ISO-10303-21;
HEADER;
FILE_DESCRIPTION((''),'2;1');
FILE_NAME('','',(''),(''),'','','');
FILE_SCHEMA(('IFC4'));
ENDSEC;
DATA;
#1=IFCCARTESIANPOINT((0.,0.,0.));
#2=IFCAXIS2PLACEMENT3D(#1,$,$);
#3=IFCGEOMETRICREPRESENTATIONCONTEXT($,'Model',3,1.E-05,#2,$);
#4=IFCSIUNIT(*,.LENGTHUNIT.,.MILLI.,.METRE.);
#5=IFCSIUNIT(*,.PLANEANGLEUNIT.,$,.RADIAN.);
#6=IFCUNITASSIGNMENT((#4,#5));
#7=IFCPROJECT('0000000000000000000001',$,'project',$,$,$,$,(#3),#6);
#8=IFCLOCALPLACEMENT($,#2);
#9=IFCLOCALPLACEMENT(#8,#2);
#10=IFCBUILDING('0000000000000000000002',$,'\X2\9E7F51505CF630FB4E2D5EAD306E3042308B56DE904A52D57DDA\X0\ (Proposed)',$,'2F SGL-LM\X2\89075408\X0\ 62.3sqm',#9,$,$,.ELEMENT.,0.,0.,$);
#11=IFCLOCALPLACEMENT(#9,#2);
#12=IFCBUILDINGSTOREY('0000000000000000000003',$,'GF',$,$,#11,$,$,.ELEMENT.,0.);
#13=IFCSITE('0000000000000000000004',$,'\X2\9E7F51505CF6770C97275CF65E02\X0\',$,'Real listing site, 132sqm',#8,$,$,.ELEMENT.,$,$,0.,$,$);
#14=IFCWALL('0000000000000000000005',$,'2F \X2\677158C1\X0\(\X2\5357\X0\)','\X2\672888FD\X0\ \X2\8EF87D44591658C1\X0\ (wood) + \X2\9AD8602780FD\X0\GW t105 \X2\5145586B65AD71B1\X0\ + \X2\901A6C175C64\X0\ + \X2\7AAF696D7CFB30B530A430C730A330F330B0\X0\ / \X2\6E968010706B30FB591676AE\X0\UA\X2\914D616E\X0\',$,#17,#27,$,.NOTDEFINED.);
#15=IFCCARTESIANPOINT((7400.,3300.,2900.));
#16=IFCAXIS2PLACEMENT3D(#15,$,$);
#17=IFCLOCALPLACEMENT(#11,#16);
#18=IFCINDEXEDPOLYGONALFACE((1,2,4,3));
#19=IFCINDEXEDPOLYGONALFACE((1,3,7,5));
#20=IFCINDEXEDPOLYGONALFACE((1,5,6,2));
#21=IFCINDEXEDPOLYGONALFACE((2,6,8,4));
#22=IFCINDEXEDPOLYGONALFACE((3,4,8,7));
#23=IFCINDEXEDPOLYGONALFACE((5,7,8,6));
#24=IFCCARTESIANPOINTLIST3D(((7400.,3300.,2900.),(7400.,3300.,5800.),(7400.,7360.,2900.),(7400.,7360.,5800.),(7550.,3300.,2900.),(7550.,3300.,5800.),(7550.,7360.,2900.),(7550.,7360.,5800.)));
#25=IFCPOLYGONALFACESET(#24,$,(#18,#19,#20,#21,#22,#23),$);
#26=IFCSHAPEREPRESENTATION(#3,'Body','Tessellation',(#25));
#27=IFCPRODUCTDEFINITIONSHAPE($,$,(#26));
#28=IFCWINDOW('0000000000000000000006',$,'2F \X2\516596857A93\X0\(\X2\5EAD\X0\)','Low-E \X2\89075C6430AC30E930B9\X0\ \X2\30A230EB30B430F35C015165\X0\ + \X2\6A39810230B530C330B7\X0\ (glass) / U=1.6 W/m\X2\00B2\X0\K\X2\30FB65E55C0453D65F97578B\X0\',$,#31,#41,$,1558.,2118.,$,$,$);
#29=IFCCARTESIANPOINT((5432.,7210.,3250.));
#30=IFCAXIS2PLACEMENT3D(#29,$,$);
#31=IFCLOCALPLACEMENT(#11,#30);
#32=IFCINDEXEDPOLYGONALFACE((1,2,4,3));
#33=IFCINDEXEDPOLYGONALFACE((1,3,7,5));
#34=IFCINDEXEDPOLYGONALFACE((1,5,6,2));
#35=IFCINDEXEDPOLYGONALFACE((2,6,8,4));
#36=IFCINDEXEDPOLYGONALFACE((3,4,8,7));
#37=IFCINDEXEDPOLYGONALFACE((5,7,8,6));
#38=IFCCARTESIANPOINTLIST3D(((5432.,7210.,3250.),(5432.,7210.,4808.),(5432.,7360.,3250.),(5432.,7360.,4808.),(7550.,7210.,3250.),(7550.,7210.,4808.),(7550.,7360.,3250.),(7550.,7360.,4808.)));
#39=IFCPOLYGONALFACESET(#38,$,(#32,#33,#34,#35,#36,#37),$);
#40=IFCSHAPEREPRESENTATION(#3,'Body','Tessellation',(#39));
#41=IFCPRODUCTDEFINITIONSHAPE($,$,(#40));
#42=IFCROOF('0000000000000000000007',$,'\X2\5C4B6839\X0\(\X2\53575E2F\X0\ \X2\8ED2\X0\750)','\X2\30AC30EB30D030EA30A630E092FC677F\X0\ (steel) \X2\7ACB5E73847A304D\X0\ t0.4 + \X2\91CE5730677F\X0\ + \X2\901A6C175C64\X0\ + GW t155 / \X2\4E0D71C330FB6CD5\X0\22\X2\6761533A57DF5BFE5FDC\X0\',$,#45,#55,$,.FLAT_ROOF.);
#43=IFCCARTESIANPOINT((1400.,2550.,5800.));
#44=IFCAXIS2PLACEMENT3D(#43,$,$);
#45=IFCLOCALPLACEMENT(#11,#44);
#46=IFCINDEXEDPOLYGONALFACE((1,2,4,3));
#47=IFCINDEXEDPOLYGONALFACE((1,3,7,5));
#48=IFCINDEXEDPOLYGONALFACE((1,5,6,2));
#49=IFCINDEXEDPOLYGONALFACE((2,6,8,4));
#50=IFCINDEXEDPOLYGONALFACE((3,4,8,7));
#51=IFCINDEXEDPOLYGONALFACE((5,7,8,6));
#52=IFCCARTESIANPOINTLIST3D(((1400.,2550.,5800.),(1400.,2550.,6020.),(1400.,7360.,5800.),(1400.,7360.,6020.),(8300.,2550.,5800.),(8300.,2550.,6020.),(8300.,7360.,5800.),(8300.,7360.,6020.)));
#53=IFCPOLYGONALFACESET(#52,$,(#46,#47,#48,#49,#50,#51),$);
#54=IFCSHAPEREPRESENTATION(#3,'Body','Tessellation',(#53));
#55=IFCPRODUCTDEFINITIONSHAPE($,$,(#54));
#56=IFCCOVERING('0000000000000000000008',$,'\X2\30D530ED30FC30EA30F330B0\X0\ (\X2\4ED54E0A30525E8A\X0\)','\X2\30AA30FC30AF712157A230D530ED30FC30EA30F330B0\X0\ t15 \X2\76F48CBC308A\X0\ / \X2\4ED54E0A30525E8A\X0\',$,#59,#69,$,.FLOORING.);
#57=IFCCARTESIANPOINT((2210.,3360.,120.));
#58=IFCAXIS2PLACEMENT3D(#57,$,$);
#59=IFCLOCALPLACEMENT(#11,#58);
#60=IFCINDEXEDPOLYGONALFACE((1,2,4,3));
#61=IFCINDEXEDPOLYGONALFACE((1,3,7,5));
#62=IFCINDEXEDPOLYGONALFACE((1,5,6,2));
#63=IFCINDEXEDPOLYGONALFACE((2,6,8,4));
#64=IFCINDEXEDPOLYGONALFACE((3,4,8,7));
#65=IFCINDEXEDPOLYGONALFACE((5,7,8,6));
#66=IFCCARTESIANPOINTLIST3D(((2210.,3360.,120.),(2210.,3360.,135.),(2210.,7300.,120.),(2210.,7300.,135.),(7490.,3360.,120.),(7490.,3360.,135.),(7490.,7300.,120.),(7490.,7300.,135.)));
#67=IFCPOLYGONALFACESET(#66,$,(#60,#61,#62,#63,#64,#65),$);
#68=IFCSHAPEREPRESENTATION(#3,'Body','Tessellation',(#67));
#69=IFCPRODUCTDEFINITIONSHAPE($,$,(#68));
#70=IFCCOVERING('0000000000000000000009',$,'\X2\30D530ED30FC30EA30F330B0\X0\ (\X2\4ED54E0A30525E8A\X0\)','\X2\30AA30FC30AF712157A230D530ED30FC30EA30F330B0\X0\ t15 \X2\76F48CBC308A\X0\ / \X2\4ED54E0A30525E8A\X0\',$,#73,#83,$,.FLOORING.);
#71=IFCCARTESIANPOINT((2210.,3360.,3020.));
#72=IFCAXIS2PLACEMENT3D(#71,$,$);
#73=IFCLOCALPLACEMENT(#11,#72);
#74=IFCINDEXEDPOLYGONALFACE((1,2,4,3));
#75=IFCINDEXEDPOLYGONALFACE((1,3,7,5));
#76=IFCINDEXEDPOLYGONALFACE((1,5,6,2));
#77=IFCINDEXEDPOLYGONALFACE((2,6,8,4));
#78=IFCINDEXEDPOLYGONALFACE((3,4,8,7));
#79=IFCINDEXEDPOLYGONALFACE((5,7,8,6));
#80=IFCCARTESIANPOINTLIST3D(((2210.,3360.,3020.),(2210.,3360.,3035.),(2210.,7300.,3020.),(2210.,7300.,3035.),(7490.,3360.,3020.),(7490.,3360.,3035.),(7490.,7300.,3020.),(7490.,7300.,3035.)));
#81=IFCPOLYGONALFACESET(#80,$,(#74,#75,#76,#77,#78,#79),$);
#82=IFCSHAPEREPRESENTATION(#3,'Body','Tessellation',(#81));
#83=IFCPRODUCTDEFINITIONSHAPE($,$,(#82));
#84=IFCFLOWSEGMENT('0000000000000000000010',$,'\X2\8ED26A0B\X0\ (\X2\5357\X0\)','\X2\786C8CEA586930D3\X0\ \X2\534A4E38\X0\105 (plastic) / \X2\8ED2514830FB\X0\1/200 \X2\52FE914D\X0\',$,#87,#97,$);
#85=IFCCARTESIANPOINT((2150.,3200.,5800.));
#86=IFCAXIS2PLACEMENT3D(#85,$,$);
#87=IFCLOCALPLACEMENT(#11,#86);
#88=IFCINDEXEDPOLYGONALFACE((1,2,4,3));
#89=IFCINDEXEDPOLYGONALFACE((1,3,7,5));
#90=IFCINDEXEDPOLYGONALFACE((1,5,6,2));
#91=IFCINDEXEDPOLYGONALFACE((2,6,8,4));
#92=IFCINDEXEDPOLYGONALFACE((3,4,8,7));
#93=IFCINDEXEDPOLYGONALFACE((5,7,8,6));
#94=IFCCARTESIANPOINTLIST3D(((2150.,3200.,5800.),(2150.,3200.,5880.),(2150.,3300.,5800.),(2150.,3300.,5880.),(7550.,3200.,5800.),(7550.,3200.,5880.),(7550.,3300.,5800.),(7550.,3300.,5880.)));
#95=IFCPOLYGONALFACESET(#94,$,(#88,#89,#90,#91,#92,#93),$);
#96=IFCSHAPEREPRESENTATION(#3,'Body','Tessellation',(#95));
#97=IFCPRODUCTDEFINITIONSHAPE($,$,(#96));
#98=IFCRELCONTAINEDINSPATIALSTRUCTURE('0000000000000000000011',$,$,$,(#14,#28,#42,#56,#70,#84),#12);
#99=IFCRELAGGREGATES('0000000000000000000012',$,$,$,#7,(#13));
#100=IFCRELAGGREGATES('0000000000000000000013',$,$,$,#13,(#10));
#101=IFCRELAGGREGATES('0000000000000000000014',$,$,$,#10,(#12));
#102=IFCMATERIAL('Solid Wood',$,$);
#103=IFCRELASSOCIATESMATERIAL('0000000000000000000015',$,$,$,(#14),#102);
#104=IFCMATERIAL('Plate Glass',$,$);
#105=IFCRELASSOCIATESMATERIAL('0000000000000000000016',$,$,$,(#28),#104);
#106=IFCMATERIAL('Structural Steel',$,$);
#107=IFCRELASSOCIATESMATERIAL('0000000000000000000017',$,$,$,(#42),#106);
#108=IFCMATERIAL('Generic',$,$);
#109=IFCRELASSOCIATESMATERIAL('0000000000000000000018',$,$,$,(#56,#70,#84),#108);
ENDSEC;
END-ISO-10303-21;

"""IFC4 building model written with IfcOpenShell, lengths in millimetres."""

from ifc_helpers import new_model, si_unit, frame, frame_2d, origin, place, context, project, spatial, rectangle, extrude, material, element, fill, save


model = new_model("IFC4")

# Units and contexts
model_context = context("Model", 3, precision=1e-05, world=origin())
ifc_project = project(units=[si_unit("LENGTHUNIT", "METRE", prefix="MILLI"), si_unit("PLANEANGLEUNIT", "RADIAN")], contexts=[model_context])

# Site, building, storey
site_placement = place(None, origin())
site = spatial("IfcSite", under=ifc_project, at=site_placement, Name="鹿児島県霧島市", ObjectType="Real listing site, 132sqm", CompositionType="ELEMENT", RefElevation=0.0)
building_placement = place(site_placement, origin())
building = spatial("IfcBuilding", under=site, at=building_placement, Name="鹿児島・中庭のある回遊動線 (Proposed)", ObjectType="2F SGL-LM複合 62.3sqm", CompositionType="ELEMENT", ElevationOfRefHeight=0.0, ElevationOfTerrain=0.0)
storey_placement = place(building_placement, origin())
storey = spatial("IfcBuildingStorey", under=building, at=storey_placement, Name="GF", CompositionType="ELEMENT", Elevation=0.0)

# Shared definitions
ifc_material_1 = material(Name="Solid Wood")

# Wall, opening, window
ifc_material_2 = material(Name="Plate Glass")
wall_1_placement = place(storey_placement, frame((7400.0, 3300.0, 2900.0)))
wall_1 = element("IfcWall", 1, at=wall_1_placement, inside=storey, material=ifc_material_1, Name="2F 東壁(南)", Description="木製 軸組外壁 (wood) + 高性能GW t105 充填断熱 + 通気層 + 窯業系サイディング / 準耐火・外皮UA配慮", PredefinedType="NOTDEFINED", context=model_context, shape_type="SweptSolid", body=[
    extrude(rectangle(XDim=150.0, YDim=4060.0, at=frame_2d((75.0, 2030.0))), frame((7400.0, 3300.0, 2900.0)), (0.0, 0.0, 1.0), 2900.0),
])
opening_1_placement = place(storey_placement, frame((5432.0, 7210.0, 3250.0)))
opening_1 = element("IfcOpeningElement", 2, at=opening_1_placement, cuts=wall_1, PredefinedType="NOTDEFINED", context=model_context, shape_type="SweptSolid", body=[
    extrude(rectangle(XDim=2118.0, YDim=150.0, at=frame_2d((1059.0, 75.0))), frame((5432.0, 7210.0, 3250.0)), (0.0, 0.0, 1.0), 1558.0),
])
window_1_placement = place(storey_placement, frame((5432.0, 7210.0, 3250.0)))
window_1 = element("IfcWindow", 3, at=window_1_placement, inside=storey, material=ifc_material_2, Name="2F 入隅窓(庭)", Description="Low-E 複層ガラス アルゴン封入 + 樹脂サッシ (glass) / U=1.6 W/m²K・日射取得型", OverallHeight=1558.0, OverallWidth=2118.0, context=model_context, shape_type="SweptSolid", body=[
    extrude(rectangle(XDim=2118.0, YDim=150.0, at=frame_2d((1059.0, 75.0))), frame((5432.0, 7210.0, 3250.0)), (0.0, 0.0, 1.0), 1558.0),
])
fill(opening_1, window_1)

# Roof
ifc_material_3 = material(Name="Structural Steel")
for number, where, name in (
    (4, (1400.0, 2550.0, 5800.0), "屋根(南帯 軒750)"),
):
    element("IfcRoof", number, at=place(storey_placement, frame(where)), inside=storey, material=ifc_material_3, Name=name, Description="ガルバリウム鋼板 (steel) 立平葺き t0.4 + 野地板 + 通気層 + GW t155 / 不燃・法22条区域対応", PredefinedType="FLAT_ROOF", context=model_context, shape_type="SweptSolid", body=[
        extrude(rectangle(XDim=6900.0, YDim=4810.0, at=frame_2d((3450.0, 2405.0))), frame((1400.0, 2550.0, 5800.0)), (0.0, 0.0, 1.0), 220.0),
    ])

# Coverings
ifc_material_4 = material(Name="Generic")
covering_1_placement = place(storey_placement, frame((2210.0, 3360.0, 120.0)))
element("IfcCovering", 5, at=covering_1_placement, inside=storey, material=ifc_material_4, Name="フローリング (仕上げ床)", Description="オーク無垢フローリング t15 直貼り / 仕上げ床", PredefinedType="FLOORING", context=model_context, shape_type="SweptSolid", body=[
    extrude(rectangle(XDim=5280.0, YDim=3940.0, at=frame_2d((2640.0, 1970.0))), frame((2210.0, 3360.0, 120.0)), (0.0, 0.0, 1.0), 15.0),
])
covering_2_placement = place(storey_placement, frame((2210.0, 3360.0, 3020.0)))
element("IfcCovering", 6, at=covering_2_placement, inside=storey, material=ifc_material_4, Name="フローリング (仕上げ床)", Description="オーク無垢フローリング t15 直貼り / 仕上げ床", PredefinedType="FLOORING", context=model_context, shape_type="SweptSolid", body=[
    extrude(rectangle(XDim=5280.0, YDim=3940.0, at=frame_2d((2640.0, 1970.0))), frame((2210.0, 3360.0, 3020.0)), (0.0, 0.0, 1.0), 15.0),
])

# Flow segment
flow_segment_placement = place(storey_placement, frame((2150.0, 3200.0, 5800.0)))
element("IfcFlowSegment", 7, at=flow_segment_placement, inside=storey, material=ifc_material_4, Name="軒樋 (南)", Description="硬質塩ビ 半丸105 (plastic) / 軒先・1/200 勾配", context=model_context, shape_type="SweptSolid", body=[
    extrude(rectangle(XDim=5400.0, YDim=100.0, at=frame_2d((2700.0, 50.0))), frame((2150.0, 3200.0, 5800.0)), (0.0, 0.0, 1.0), 80.0),
])

save(model, "model.ifc")
